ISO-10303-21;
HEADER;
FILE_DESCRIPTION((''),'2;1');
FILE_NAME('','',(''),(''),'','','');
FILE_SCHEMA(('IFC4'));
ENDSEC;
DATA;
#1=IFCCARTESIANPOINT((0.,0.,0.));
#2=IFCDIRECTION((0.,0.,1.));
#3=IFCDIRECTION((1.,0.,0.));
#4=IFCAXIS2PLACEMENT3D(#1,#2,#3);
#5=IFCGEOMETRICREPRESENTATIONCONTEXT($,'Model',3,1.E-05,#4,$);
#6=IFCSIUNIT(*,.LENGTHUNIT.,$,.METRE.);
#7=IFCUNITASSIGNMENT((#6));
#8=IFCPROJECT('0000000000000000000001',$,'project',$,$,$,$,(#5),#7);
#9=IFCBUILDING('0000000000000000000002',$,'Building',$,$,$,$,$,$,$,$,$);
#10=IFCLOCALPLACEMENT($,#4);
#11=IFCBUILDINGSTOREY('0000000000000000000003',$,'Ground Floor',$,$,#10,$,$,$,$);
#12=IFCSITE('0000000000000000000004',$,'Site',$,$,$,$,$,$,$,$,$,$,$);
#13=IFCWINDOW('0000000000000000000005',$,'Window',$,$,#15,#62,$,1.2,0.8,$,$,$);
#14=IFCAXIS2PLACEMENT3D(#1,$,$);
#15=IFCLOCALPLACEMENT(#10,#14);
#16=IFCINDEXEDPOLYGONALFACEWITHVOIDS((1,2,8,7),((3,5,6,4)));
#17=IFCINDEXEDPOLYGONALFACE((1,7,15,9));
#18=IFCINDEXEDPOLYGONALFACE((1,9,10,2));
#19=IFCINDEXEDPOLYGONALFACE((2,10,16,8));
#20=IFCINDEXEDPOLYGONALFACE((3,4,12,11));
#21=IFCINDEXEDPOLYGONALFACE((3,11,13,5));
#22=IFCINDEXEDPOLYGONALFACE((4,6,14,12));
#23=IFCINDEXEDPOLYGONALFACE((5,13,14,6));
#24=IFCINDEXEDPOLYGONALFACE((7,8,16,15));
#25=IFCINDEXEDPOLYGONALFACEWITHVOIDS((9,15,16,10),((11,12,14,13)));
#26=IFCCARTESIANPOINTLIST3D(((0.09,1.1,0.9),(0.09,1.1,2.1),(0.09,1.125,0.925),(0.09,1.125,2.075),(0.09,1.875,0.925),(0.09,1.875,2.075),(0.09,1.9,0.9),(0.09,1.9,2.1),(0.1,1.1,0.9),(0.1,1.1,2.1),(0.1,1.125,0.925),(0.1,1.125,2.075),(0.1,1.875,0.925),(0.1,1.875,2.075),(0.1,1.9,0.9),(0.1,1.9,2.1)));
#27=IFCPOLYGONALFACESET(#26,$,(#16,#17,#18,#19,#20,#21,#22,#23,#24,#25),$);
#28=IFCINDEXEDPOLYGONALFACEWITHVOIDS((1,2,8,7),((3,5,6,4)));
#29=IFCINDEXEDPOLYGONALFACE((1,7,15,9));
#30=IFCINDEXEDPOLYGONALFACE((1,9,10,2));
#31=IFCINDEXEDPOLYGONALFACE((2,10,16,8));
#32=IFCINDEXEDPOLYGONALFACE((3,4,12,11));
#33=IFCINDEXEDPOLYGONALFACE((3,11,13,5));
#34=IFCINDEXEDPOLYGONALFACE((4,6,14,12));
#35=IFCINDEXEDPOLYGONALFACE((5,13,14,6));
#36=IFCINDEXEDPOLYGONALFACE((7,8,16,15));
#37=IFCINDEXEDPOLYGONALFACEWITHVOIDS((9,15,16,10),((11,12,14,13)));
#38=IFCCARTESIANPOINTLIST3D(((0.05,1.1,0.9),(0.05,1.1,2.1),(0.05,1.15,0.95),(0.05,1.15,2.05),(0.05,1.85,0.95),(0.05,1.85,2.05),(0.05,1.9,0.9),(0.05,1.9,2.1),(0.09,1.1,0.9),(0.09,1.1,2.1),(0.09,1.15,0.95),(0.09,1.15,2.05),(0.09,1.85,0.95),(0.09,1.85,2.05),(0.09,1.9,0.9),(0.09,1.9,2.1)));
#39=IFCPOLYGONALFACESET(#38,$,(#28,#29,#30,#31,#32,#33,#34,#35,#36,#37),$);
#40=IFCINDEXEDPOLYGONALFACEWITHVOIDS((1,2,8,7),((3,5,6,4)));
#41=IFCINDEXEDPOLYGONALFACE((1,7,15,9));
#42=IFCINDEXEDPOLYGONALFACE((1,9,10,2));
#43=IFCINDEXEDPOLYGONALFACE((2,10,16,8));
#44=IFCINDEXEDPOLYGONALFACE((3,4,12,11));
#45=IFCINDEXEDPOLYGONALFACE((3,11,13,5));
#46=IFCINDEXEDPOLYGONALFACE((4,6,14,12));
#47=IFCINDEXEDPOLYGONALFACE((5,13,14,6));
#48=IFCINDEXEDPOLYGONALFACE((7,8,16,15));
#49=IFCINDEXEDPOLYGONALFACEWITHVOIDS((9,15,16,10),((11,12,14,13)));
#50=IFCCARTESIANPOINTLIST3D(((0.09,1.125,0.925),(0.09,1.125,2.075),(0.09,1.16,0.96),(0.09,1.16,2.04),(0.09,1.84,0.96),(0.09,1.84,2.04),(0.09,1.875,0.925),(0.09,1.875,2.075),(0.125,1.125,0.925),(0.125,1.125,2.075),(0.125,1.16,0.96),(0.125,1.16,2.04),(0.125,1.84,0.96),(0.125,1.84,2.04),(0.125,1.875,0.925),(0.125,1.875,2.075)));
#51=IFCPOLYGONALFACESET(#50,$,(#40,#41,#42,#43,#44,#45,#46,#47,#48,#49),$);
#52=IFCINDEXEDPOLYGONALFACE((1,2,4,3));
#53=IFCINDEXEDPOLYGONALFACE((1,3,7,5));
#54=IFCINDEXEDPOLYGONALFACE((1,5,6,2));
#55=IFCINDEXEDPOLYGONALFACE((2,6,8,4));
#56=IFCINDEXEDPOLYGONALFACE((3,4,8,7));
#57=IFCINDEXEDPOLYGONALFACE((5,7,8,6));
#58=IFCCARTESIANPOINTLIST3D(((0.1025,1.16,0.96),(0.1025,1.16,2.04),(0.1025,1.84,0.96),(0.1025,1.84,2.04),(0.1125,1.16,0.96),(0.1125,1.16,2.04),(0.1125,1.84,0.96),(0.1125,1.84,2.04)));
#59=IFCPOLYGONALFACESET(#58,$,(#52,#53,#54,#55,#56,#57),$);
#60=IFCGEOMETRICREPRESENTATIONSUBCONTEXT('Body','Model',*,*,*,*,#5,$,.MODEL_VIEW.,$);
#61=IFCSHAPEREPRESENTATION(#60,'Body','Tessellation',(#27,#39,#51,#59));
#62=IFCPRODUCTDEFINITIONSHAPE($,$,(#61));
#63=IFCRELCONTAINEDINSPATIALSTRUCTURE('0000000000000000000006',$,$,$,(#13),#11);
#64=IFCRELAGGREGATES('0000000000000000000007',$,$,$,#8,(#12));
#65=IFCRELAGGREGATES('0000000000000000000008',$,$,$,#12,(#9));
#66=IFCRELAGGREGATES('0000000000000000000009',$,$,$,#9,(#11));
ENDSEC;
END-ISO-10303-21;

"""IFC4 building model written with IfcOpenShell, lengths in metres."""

from ifc_helpers import new_model, si_unit, frame, origin_with_axes, place, context, subcontext, project, spatial, line, indexed_curve, outline, extrude, element, save


model = new_model("IFC4")

# Units and contexts
model_context = context("Model", 3, precision=1e-05, world=origin_with_axes())
body_context = subcontext(model_context, "Body", "Model", "MODEL_VIEW")
ifc_project = project(units=[si_unit("LENGTHUNIT", "METRE")], contexts=[model_context])

# Site, building, storey
site = spatial("IfcSite", under=ifc_project, Name="Site")
building = spatial("IfcBuilding", under=site, Name="Building")
storey_placement = place(None, origin_with_axes())
storey = spatial("IfcBuildingStorey", under=building, at=storey_placement, Name="Ground Floor")

# Window
window_1_placement = place(storey_placement, frame((0.0, 1.9, 0.9), z_axis=(0.0, 0.0, 1.0), x_axis=(0.0, -1.0, 0.0)))
element("IfcWindow", 1, at=window_1_placement, inside=storey, Name="Window", OverallHeight=1.2, OverallWidth=0.8, context=body_context, shape_type="SweptSolid", body=[
    extrude(outline(indexed_curve([(0.0, 0.0), (0.8, 0.0), (0.8, 1.2), (0.0, 1.2)], segments=[line(1, 2, 3, 4, 1)]), holes=[indexed_curve([(0.025, 0.025), (0.775, 0.025), (0.775, 1.175), (0.025, 1.175)], segments=[line(1, 2, 3, 4, 1)])]), frame((0.0, 0.09, 0.0), z_axis=(0.0, -1.0, 0.0), x_axis=(1.0, 0.0, 0.0)), (0.0, 0.0, -1.0), 0.01),
    extrude(outline(indexed_curve([(0.0, 0.0), (0.8, 0.0), (0.8, 1.2), (0.0, 1.2)], segments=[line(1, 2, 3, 4, 1)]), holes=[indexed_curve([(0.05, 0.05), (0.75, 0.05), (0.75, 1.15), (0.05, 1.15)], segments=[line(1, 2, 3, 4, 1)])]), frame((0.0, 0.05, 0.0), z_axis=(0.0, -1.0, 0.0), x_axis=(1.0, 0.0, 0.0)), (0.0, 0.0, -1.0), 0.04),
    extrude(outline(indexed_curve([(0.0, 0.0), (0.75, 0.0), (0.75, 1.15), (0.0, 1.15)], segments=[line(1, 2, 3, 4, 1)]), holes=[indexed_curve([(0.035, 0.035), (0.715, 0.035), (0.715, 1.115), (0.035, 1.115)], segments=[line(1, 2, 3, 4, 1)])]), frame((0.025, 0.09, 0.025), z_axis=(0.0, -1.0, 0.0), x_axis=(1.0, 0.0, 0.0)), (0.0, 0.0, -1.0), 0.035),
    extrude(outline(indexed_curve([(0.035, 0.035), (0.715, 0.035), (0.715, 1.115), (0.035, 1.115)], segments=[line(1, 2, 3, 4, 1)])), frame((0.025, 0.1025, 0.025), z_axis=(0.0, -1.0, 0.0), x_axis=(1.0, 0.0, 0.0)), (0.0, 0.0, -1.0), 0.01),
])

save(model, "model.ifc")
